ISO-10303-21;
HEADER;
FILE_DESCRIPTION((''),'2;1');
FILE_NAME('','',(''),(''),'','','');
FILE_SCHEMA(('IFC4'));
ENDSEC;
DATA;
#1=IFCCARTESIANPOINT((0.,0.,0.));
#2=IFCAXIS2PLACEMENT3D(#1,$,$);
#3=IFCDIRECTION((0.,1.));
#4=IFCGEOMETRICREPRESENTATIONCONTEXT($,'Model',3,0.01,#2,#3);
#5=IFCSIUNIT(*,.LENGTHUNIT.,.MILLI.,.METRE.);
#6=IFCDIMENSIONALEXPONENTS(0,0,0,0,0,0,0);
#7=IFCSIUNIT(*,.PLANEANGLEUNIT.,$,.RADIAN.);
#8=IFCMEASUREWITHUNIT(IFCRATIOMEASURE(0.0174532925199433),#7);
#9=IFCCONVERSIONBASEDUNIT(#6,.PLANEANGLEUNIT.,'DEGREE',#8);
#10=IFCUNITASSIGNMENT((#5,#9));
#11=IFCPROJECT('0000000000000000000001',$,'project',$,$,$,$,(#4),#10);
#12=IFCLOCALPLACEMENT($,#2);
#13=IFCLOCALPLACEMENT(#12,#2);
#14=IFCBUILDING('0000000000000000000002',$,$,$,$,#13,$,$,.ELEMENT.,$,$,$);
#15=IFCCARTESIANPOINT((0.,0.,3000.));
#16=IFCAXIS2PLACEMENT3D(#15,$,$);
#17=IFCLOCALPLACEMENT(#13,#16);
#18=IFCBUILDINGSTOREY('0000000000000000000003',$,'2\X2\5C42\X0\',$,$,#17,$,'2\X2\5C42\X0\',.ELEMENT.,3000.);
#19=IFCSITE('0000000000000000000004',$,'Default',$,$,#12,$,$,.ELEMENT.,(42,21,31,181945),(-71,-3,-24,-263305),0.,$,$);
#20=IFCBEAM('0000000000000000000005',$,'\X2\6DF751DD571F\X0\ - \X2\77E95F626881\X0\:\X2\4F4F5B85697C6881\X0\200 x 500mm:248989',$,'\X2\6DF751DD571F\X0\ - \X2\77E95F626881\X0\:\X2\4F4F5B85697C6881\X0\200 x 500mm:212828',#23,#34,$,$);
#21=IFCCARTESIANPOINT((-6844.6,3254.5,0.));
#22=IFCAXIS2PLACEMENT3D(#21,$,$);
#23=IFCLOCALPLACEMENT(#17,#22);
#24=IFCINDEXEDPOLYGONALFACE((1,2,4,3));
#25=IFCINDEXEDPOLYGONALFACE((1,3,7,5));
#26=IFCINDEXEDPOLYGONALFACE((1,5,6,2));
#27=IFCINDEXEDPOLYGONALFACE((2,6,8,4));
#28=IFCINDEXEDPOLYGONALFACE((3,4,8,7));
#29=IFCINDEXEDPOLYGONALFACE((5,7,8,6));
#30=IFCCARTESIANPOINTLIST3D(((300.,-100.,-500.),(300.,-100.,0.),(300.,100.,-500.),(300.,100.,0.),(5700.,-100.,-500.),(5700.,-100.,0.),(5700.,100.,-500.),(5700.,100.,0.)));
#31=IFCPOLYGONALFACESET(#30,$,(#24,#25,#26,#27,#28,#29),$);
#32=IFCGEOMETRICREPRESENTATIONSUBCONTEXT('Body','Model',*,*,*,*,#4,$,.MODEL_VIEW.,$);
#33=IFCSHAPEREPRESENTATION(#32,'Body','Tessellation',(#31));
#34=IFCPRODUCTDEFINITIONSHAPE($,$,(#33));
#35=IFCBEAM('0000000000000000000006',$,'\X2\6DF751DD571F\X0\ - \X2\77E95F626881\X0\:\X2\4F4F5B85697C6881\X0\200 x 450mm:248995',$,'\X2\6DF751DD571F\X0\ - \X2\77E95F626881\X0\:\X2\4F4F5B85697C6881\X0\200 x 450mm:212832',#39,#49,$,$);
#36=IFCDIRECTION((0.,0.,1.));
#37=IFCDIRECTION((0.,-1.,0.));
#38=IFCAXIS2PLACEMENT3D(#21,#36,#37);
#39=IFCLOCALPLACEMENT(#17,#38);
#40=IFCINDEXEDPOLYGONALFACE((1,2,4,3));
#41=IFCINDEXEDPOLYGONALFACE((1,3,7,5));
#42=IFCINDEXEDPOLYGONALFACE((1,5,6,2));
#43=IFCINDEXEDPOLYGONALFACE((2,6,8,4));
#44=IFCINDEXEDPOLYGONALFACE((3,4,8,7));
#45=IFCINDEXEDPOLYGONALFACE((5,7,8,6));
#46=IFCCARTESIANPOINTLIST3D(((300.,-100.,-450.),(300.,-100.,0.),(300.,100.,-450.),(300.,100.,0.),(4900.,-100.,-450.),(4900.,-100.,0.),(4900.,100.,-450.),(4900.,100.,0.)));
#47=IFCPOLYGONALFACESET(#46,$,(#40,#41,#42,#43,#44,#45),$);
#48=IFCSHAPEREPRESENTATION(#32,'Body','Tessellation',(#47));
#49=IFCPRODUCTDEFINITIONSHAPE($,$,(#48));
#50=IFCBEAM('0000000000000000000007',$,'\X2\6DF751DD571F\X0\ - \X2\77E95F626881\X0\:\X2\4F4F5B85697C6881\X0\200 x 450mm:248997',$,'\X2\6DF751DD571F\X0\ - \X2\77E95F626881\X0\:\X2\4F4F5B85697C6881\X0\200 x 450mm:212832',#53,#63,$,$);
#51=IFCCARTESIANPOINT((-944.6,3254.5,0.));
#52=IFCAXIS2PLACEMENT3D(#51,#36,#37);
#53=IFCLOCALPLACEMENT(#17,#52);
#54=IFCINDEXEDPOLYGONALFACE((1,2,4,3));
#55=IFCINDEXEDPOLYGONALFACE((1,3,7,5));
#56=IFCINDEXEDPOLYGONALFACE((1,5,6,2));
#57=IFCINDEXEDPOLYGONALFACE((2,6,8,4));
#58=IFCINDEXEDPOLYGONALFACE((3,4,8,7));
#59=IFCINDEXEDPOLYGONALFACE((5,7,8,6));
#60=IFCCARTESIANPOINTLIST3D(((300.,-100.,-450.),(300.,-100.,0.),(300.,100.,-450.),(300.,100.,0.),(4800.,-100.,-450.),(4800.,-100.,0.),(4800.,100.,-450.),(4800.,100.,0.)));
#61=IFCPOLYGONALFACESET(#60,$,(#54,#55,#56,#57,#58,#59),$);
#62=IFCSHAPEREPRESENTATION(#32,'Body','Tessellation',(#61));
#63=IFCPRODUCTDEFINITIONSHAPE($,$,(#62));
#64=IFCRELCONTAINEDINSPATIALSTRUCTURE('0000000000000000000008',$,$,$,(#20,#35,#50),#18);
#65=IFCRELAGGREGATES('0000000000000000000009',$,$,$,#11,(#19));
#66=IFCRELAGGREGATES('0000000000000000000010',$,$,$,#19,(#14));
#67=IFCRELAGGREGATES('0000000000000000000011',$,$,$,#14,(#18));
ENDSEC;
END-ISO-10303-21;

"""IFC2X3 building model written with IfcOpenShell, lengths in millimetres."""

from ifc_helpers import new_model, entity, si_unit, converted_unit, direction, frame, frame_2d, origin, place, context, subcontext, project, spatial, rectangle, extrude, element, save


model = new_model("IFC2X3")

# Units and contexts
model_context = context("Model", 3, precision=0.01, world=origin(), true_north=direction((0.0, 1.0)))
body_context = subcontext(model_context, "Body", "Model", "MODEL_VIEW")
ifc_project = project(units=[si_unit("LENGTHUNIT", "METRE", prefix="MILLI"), converted_unit("PLANEANGLEUNIT", "DEGREE", entity("IfcRatioMeasure", 0.0174532925199433), si_unit("PLANEANGLEUNIT", "RADIAN"), dimensions=[0, 0, 0, 0, 0, 0, 0])], contexts=[model_context])

# Site, building, storey
site_placement = place(None, origin())
site = spatial("IfcSite", under=ifc_project, at=site_placement, Name="Default", CompositionType="ELEMENT", RefLatitude=(42, 21, 31, 181945), RefLongitude=(-71, -3, -24, -263305), RefElevation=0.0)
building_placement = place(site_placement, origin())
building = spatial("IfcBuilding", under=site, at=building_placement, CompositionType="ELEMENT")
storey_placement = place(building_placement, frame((0.0, 0.0, 3000.0)))
storey = spatial("IfcBuildingStorey", under=building, at=storey_placement, Name="2层", LongName="2层", CompositionType="ELEMENT", Elevation=3000.0)

# Beams
beam_1_placement = place(storey_placement, frame((-6844.6, 3254.5, 0.0)))
element("IfcBeam", 1, at=beam_1_placement, inside=storey, Name="混凝土 - 矩形梁:住宅楼梁200 x 500mm:248989", ObjectType="混凝土 - 矩形梁:住宅楼梁200 x 500mm:212828", context=body_context, shape_type="SweptSolid", body=[
    extrude(rectangle(XDim=500.0, YDim=200.0, at=frame_2d((0.0, 0.0), x_axis=(1.0, 0.0))), frame((300.0, 0.0, -250.0), z_axis=(1.0, 0.0, 0.0), x_axis=(0.0, 0.0, -1.0)), (0.0, 0.0, 1.0), 5400.0),
])
beam_2_placement = place(storey_placement, frame((-6844.6, 3254.5, 0.0), z_axis=(0.0, 0.0, 1.0), x_axis=(0.0, -1.0, 0.0)))
element("IfcBeam", 2, at=beam_2_placement, inside=storey, Name="混凝土 - 矩形梁:住宅楼梁200 x 450mm:248995", ObjectType="混凝土 - 矩形梁:住宅楼梁200 x 450mm:212832", context=body_context, shape_type="SweptSolid", body=[
    extrude(rectangle(XDim=450.0, YDim=200.0, at=frame_2d((0.0, 0.0), x_axis=(1.0, 0.0))), frame((300.0, 0.0, -225.0), z_axis=(1.0, 0.0, 0.0), x_axis=(0.0, 0.0, -1.0)), (0.0, 0.0, 1.0), 4600.0),
])
beam_3_placement = place(storey_placement, frame((-944.6, 3254.5, 0.0), z_axis=(0.0, 0.0, 1.0), x_axis=(0.0, -1.0, 0.0)))
element("IfcBeam", 3, at=beam_3_placement, inside=storey, Name="混凝土 - 矩形梁:住宅楼梁200 x 450mm:248997", ObjectType="混凝土 - 矩形梁:住宅楼梁200 x 450mm:212832", context=body_context, shape_type="SweptSolid", body=[
    extrude(rectangle(XDim=450.0, YDim=200.0, at=frame_2d((0.0, 0.0), x_axis=(1.0, 0.0))), frame((300.0, 0.0, -225.0), z_axis=(1.0, 0.0, 0.0), x_axis=(0.0, 0.0, -1.0)), (0.0, 0.0, 1.0), 4500.0),
])

save(model, "model.ifc")
